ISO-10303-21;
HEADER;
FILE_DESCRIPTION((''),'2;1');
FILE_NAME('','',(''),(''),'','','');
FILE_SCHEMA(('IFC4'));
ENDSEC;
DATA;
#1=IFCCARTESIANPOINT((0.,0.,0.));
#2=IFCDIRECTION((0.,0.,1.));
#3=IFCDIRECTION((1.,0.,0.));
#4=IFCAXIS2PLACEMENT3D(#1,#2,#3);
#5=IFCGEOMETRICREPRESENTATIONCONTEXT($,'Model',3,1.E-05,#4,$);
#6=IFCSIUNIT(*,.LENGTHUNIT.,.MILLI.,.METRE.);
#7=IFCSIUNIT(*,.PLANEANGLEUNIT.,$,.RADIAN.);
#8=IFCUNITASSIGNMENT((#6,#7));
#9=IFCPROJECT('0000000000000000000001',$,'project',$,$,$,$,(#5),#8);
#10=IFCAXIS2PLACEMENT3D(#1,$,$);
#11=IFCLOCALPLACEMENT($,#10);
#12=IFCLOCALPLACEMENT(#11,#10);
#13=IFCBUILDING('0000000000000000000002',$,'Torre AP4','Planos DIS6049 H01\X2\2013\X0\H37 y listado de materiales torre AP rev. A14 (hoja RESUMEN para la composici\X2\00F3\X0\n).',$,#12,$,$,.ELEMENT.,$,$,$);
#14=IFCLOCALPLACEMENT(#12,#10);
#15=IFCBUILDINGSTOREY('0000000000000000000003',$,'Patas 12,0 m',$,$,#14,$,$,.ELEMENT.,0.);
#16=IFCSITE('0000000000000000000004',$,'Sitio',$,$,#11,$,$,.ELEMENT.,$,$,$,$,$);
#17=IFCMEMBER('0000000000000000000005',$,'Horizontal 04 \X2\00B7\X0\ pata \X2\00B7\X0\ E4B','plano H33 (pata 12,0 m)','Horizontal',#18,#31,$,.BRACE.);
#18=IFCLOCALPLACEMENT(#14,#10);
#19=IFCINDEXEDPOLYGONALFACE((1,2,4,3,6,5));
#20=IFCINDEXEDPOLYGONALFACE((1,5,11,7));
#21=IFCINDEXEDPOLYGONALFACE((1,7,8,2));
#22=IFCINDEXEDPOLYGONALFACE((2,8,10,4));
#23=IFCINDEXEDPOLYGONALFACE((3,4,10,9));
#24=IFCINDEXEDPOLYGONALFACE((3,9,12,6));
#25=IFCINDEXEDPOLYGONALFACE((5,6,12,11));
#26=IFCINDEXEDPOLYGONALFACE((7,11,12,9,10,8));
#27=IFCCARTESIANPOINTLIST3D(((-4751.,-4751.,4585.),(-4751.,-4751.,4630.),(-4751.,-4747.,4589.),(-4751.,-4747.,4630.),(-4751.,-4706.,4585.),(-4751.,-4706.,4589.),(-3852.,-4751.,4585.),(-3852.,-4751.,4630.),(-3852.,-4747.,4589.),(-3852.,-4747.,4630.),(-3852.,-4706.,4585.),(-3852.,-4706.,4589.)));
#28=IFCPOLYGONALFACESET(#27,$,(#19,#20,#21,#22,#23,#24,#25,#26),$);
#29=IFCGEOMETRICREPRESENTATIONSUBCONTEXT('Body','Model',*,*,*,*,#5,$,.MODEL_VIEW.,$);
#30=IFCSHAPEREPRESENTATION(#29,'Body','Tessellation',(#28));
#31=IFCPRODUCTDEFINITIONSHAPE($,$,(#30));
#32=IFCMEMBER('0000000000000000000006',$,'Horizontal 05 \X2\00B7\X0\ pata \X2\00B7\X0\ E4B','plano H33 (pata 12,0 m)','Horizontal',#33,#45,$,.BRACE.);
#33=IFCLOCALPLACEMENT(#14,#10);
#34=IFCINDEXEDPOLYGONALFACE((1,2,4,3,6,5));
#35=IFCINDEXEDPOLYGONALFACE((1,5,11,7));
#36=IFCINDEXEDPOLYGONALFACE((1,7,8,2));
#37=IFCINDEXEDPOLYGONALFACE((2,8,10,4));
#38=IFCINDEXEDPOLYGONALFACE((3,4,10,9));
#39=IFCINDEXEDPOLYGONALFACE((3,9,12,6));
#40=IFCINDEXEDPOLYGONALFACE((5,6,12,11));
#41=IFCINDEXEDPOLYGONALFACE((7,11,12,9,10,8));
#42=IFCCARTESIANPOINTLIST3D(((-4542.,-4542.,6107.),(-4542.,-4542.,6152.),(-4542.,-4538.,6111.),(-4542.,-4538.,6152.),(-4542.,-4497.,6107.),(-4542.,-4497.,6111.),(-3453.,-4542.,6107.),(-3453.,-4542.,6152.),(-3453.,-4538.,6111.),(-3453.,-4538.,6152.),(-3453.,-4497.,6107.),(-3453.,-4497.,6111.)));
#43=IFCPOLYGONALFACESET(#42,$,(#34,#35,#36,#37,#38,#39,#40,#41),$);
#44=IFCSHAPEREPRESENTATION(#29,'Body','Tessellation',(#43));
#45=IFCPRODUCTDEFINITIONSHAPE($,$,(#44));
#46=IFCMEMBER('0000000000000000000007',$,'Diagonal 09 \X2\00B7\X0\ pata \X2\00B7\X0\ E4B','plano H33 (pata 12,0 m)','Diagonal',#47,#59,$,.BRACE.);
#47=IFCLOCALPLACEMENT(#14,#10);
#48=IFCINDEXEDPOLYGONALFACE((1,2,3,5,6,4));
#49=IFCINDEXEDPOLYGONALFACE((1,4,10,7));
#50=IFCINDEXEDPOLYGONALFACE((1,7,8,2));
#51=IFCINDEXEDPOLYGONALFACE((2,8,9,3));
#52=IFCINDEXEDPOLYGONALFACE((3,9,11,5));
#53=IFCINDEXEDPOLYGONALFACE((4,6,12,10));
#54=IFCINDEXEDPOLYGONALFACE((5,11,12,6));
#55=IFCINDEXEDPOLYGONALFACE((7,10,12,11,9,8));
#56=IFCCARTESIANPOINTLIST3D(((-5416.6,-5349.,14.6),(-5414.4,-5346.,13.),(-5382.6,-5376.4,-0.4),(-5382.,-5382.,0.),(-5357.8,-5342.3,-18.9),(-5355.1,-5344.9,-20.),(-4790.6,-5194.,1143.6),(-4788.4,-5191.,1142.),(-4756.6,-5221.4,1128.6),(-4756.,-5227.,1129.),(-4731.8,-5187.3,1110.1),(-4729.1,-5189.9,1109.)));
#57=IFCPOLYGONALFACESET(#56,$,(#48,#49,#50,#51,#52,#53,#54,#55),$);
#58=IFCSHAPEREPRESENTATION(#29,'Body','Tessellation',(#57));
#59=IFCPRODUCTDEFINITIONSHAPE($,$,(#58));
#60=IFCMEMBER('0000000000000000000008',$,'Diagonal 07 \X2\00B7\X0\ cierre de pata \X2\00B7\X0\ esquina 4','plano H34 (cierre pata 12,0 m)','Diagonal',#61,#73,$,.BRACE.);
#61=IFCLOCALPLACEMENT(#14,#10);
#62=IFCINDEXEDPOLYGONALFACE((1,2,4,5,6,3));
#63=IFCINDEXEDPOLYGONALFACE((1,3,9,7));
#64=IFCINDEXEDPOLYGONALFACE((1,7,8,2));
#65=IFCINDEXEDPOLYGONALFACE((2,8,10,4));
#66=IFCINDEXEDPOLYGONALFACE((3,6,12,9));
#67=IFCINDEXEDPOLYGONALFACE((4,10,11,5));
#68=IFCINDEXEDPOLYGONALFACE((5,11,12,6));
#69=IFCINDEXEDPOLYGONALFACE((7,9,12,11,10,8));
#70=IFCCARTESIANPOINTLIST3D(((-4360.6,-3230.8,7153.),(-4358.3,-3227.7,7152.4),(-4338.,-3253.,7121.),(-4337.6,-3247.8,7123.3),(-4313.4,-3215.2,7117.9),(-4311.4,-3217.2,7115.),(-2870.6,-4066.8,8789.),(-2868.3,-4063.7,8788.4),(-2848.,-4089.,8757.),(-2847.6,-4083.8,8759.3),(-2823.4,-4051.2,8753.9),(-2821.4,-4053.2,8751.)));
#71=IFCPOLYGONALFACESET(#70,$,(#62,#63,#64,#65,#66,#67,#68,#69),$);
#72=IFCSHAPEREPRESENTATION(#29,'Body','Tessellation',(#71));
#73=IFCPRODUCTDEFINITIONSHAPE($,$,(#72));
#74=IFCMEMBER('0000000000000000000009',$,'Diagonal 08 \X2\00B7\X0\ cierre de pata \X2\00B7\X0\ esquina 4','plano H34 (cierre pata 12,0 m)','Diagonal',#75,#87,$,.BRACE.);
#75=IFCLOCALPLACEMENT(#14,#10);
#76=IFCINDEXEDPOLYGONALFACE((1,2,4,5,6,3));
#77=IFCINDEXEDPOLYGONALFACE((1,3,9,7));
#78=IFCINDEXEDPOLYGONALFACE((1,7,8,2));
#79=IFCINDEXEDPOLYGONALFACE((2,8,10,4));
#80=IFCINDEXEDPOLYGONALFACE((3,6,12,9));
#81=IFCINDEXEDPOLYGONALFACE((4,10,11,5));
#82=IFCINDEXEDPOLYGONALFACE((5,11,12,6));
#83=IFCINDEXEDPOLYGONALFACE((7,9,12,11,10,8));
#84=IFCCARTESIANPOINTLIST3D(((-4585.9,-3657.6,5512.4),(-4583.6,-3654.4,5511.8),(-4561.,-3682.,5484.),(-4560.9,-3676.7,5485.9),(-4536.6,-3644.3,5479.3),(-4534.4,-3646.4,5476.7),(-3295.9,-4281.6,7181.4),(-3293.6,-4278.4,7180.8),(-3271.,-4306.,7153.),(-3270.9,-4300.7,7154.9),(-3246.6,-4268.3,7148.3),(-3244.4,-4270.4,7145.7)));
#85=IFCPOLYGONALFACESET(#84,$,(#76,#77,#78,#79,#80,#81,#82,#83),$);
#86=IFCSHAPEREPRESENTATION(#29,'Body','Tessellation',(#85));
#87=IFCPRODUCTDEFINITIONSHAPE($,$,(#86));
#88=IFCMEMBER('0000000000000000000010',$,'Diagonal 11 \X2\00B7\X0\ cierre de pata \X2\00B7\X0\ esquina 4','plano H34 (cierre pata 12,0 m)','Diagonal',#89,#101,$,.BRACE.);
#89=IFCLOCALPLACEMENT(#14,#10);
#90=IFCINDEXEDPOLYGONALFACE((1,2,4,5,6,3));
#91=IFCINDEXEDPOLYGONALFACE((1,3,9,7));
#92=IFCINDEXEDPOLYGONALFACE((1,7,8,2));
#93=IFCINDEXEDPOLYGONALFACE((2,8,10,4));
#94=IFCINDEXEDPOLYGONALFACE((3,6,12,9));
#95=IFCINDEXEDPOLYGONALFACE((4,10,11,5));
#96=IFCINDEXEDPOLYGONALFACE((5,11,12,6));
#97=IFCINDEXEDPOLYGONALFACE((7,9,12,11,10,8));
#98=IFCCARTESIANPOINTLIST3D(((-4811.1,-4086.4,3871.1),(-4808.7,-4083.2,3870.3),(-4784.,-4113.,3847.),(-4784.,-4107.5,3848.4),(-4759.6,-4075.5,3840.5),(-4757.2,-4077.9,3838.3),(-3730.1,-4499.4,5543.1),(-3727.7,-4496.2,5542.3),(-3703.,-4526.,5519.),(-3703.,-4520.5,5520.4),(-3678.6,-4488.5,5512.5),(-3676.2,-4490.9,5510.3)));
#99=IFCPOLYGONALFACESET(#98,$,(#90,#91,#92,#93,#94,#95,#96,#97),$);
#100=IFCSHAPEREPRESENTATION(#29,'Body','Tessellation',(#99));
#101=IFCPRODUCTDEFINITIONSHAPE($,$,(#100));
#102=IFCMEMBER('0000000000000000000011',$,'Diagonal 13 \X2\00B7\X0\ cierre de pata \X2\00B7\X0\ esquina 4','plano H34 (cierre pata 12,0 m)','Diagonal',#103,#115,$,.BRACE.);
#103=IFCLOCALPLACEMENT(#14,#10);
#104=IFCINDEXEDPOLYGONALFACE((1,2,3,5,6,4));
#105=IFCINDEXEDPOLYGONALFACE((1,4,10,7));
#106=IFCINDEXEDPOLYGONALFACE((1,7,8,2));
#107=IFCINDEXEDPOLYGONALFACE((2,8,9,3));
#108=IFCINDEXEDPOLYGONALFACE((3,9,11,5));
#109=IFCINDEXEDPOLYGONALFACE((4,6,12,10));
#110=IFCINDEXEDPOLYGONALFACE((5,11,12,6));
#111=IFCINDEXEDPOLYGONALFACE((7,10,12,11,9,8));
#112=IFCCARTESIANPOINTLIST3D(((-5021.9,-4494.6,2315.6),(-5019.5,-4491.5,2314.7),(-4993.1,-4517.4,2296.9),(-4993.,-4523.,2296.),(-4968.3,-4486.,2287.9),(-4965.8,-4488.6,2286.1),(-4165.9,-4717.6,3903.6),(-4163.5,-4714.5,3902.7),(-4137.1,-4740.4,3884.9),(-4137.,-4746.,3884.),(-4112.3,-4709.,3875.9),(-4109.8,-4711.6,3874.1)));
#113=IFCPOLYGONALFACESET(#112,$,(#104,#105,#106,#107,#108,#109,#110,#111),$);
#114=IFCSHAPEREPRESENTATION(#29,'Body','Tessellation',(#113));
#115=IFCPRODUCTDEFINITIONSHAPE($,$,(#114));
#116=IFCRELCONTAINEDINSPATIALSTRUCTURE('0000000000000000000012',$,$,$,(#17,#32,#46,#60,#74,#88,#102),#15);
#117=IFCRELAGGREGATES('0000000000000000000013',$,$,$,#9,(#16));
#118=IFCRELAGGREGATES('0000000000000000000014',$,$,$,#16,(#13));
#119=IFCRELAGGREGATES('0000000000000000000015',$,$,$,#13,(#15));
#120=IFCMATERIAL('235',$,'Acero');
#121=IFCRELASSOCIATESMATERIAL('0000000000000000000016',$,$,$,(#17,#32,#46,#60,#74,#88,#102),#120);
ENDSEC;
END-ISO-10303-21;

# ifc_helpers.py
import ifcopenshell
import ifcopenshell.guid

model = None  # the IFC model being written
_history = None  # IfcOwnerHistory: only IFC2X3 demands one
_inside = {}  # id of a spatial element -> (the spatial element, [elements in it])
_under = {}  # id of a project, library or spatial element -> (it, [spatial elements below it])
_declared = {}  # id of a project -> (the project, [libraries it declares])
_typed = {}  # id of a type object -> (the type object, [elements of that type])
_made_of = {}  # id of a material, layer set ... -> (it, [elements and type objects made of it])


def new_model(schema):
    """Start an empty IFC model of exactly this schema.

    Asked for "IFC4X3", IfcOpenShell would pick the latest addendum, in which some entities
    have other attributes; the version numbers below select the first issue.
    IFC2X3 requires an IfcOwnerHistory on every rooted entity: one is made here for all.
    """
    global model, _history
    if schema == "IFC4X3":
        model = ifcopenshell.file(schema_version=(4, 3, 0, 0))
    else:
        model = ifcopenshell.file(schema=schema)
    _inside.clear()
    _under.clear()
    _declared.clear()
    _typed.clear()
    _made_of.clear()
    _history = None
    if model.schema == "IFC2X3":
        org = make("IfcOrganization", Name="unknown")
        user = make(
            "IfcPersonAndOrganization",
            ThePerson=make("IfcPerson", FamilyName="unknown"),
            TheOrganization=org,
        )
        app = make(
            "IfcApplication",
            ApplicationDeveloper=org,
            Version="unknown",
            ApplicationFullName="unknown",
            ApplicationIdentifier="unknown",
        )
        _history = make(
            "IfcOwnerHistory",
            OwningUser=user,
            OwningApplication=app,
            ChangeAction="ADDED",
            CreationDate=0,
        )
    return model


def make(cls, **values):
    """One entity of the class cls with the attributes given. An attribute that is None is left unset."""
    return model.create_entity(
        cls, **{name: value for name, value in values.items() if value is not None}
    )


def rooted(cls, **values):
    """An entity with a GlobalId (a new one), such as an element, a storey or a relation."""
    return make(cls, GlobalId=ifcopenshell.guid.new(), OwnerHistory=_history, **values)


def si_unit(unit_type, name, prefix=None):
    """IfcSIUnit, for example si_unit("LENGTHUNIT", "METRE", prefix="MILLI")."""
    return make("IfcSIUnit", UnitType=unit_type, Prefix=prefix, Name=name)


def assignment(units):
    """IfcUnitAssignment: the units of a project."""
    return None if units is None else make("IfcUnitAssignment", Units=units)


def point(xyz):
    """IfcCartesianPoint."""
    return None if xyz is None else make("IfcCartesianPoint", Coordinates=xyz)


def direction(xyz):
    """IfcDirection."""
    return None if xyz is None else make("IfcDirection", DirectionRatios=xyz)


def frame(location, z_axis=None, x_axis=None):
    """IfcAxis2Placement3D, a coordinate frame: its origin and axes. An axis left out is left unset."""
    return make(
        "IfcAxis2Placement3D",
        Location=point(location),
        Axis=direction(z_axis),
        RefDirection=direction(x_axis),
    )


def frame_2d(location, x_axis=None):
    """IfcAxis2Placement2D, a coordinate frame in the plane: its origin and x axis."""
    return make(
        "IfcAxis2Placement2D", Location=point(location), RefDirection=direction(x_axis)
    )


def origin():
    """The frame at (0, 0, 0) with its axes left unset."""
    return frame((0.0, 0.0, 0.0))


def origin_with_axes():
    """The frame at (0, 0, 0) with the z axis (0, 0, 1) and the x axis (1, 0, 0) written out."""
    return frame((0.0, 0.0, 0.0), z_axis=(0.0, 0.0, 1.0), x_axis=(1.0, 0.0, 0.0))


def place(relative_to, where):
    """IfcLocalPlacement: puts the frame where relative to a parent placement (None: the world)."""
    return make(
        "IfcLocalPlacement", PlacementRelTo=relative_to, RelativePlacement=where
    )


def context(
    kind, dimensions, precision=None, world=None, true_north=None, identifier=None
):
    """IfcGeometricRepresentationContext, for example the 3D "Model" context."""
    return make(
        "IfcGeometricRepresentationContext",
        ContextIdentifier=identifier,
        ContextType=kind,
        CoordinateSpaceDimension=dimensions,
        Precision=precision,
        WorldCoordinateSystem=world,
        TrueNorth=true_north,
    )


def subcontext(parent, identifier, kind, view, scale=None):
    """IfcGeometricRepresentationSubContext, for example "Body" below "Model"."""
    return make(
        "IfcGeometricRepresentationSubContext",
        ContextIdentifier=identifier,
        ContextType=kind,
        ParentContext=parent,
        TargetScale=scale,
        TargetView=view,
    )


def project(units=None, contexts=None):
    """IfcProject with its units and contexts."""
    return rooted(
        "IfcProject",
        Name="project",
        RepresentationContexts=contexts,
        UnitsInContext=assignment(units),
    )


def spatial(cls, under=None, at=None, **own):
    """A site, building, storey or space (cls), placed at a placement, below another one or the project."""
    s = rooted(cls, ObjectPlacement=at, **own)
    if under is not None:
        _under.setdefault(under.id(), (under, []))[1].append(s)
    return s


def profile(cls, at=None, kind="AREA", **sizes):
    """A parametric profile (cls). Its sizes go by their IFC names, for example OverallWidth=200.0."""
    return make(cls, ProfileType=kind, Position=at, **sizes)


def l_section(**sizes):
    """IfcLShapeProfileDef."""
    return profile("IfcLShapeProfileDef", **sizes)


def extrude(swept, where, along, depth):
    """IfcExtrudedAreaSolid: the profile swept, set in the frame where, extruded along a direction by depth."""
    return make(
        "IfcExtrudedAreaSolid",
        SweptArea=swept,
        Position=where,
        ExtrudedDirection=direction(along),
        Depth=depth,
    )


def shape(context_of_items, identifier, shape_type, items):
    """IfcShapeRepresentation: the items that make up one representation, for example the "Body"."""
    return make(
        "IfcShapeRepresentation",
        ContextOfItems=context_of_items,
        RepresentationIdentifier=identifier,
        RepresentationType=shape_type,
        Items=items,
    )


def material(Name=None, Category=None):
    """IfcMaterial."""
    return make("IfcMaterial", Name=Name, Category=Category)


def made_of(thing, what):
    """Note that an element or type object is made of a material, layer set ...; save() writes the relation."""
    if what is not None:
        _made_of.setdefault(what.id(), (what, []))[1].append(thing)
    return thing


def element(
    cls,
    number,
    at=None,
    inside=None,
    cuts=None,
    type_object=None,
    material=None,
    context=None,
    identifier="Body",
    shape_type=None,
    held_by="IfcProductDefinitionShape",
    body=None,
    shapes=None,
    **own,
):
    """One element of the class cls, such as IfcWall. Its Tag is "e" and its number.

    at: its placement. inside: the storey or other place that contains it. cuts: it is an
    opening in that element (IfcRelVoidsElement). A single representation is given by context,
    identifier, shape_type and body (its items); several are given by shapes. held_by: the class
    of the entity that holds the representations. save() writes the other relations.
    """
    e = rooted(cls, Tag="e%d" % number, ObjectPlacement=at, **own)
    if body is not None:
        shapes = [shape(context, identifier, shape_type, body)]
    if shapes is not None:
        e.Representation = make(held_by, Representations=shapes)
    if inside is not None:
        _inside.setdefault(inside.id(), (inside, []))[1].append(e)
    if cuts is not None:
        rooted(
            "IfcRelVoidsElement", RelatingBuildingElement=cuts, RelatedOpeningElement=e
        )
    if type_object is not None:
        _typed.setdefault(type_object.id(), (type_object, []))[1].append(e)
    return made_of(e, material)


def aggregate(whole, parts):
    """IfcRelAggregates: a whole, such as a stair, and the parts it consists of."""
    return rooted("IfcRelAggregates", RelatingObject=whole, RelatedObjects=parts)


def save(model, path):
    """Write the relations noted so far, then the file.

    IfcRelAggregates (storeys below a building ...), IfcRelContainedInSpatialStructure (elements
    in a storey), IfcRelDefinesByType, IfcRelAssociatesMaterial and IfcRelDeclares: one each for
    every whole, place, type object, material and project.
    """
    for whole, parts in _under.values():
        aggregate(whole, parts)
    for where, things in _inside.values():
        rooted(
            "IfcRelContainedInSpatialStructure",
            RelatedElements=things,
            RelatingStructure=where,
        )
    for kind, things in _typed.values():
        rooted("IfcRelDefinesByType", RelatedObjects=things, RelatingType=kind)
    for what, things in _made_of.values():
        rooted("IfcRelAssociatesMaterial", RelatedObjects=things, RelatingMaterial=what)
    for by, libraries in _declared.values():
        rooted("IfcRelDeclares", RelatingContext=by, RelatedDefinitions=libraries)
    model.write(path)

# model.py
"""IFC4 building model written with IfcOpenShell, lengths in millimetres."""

from ifc_helpers import new_model, si_unit, frame, frame_2d, origin, origin_with_axes, place, context, subcontext, project, spatial, l_section, extrude, material, element, save


model = new_model("IFC4")

# Units and contexts
model_context = context("Model", 3, precision=1e-05, world=origin_with_axes())
body_context = subcontext(model_context, "Body", "Model", "MODEL_VIEW")
ifc_project = project(units=[si_unit("LENGTHUNIT", "METRE", prefix="MILLI"), si_unit("PLANEANGLEUNIT", "RADIAN")], contexts=[model_context])

# Site, building, storey
site_placement = place(None, origin())
site = spatial("IfcSite", under=ifc_project, at=site_placement, Name="Sitio", CompositionType="ELEMENT")
building_placement = place(site_placement, origin())
building = spatial("IfcBuilding", under=site, at=building_placement, Name="Torre AP4", Description="Planos DIS6049 H01–H37 y listado de materiales torre AP rev. A14 (hoja RESUMEN para la composición).", CompositionType="ELEMENT")
storey_placement = place(building_placement, origin())
storey = spatial("IfcBuildingStorey", under=building, at=storey_placement, Name="Patas 12,0 m", CompositionType="ELEMENT", Elevation=0.0)

# Members
ifc_material_1 = material(Name="235", Category="Acero")
member_1_placement = place(storey_placement, frame((-4751.0, -4751.0, 4585.0), z_axis=(1.0, 0.0, 0.0), x_axis=(0.0, 1.0, 0.0)))
element("IfcMember", 1, at=member_1_placement, inside=storey, material=ifc_material_1, Name="Horizontal 04 · pata · E4B", Description="plano H33 (pata 12,0 m)", ObjectType="Horizontal", PredefinedType="BRACE", context=body_context, shape_type="SweptSolid", body=[
    extrude(l_section(Depth=45.0, Width=45.0, Thickness=4.0, at=frame_2d((22.5, 22.5))), None, (0.0, 0.0, 1.0), 899.0),
])
member_2_placement = place(storey_placement, frame((-4542.0, -4542.0, 6107.0), z_axis=(1.0, 0.0, 0.0), x_axis=(0.0, 1.0, 0.0)))
element("IfcMember", 2, at=member_2_placement, inside=storey, material=ifc_material_1, Name="Horizontal 05 · pata · E4B", Description="plano H33 (pata 12,0 m)", ObjectType="Horizontal", PredefinedType="BRACE", context=body_context, shape_type="SweptSolid", body=[
    extrude(l_section(Depth=45.0, Width=45.0, Thickness=4.0, at=frame_2d((22.5, 22.5))), None, (0.0, 0.0, 1.0), 1089.0),
])
member_3_placement = place(storey_placement, frame((-5382.0, -5382.0, 0.0), z_axis=(0.481461, 0.119212, 0.868322), x_axis=(0.53876, 0.741182, -0.400484)))
element("IfcMember", 3, at=member_3_placement, inside=storey, material=ifc_material_1, Name="Diagonal 09 · pata · E4B", Description="plano H33 (pata 12,0 m)", ObjectType="Diagonal", PredefinedType="BRACE", context=body_context, shape_type="SweptSolid", body=[
    extrude(l_section(Depth=50.0, Width=50.0, Thickness=4.0, at=frame_2d((25.0, 25.0))), None, (0.0, 0.0, 1.0), 1300.2),
])
member_4_placement = place(storey_placement, frame((-4338.0, -3253.0, 7121.0), z_axis=(0.629894, -0.353417, 0.691615), x_axis=(0.591591, 0.795293, -0.1324)))
element("IfcMember", 4, at=member_4_placement, inside=storey, material=ifc_material_1, Name="Diagonal 07 · cierre de pata · esquina 4", Description="plano H34 (cierre pata 12,0 m)", ObjectType="Diagonal", PredefinedType="BRACE", context=body_context, shape_type="SweptSolid", body=[
    extrude(l_section(Depth=45.0, Width=45.0, Thickness=4.0, at=frame_2d((22.5, 22.5))), None, (0.0, 0.0, 1.0), 2365.5),
])
member_5_placement = place(storey_placement, frame((-4561.0, -3682.0, 5484.0), z_axis=(0.586422, -0.283665, 0.758712), x_axis=(0.591049, 0.790335, -0.161345)))
element("IfcMember", 5, at=member_5_placement, inside=storey, material=ifc_material_1, Name="Diagonal 08 · cierre de pata · esquina 4", Description="plano H34 (cierre pata 12,0 m)", ObjectType="Diagonal", PredefinedType="BRACE", context=body_context, shape_type="SweptSolid", body=[
    extrude(l_section(Depth=45.0, Width=45.0, Thickness=4.0, at=frame_2d((22.5, 22.5))), None, (0.0, 0.0, 1.0), 2199.8),
])
member_6_placement = place(storey_placement, frame((-4784.0, -4113.0, 3847.0), z_axis=(0.531622, -0.203108, 0.822268), x_axis=(0.595404, 0.780084, -0.192259)))
element("IfcMember", 6, at=member_6_placement, inside=storey, material=ifc_material_1, Name="Diagonal 11 · cierre de pata · esquina 4", Description="plano H34 (cierre pata 12,0 m)", ObjectType="Diagonal", PredefinedType="BRACE", context=body_context, shape_type="SweptSolid", body=[
    extrude(l_section(Depth=45.0, Width=45.0, Thickness=4.0, at=frame_2d((22.5, 22.5))), None, (0.0, 0.0, 1.0), 2033.4),
])
member_7_placement = place(storey_placement, frame((-4993.0, -4523.0, 2296.0), z_axis=(0.470912, -0.122679, 0.873608), x_axis=(0.605441, 0.765194, -0.218904)))
element("IfcMember", 7, at=member_7_placement, inside=storey, material=ifc_material_1, Name="Diagonal 13 · cierre de pata · esquina 4", Description="plano H34 (cierre pata 12,0 m)", ObjectType="Diagonal", PredefinedType="BRACE", context=body_context, shape_type="SweptSolid", body=[
    extrude(l_section(Depth=45.0, Width=45.0, Thickness=4.0, at=frame_2d((22.5, 22.5))), None, (0.0, 0.0, 1.0), 1817.7),
])

save(model, "model.ifc")
